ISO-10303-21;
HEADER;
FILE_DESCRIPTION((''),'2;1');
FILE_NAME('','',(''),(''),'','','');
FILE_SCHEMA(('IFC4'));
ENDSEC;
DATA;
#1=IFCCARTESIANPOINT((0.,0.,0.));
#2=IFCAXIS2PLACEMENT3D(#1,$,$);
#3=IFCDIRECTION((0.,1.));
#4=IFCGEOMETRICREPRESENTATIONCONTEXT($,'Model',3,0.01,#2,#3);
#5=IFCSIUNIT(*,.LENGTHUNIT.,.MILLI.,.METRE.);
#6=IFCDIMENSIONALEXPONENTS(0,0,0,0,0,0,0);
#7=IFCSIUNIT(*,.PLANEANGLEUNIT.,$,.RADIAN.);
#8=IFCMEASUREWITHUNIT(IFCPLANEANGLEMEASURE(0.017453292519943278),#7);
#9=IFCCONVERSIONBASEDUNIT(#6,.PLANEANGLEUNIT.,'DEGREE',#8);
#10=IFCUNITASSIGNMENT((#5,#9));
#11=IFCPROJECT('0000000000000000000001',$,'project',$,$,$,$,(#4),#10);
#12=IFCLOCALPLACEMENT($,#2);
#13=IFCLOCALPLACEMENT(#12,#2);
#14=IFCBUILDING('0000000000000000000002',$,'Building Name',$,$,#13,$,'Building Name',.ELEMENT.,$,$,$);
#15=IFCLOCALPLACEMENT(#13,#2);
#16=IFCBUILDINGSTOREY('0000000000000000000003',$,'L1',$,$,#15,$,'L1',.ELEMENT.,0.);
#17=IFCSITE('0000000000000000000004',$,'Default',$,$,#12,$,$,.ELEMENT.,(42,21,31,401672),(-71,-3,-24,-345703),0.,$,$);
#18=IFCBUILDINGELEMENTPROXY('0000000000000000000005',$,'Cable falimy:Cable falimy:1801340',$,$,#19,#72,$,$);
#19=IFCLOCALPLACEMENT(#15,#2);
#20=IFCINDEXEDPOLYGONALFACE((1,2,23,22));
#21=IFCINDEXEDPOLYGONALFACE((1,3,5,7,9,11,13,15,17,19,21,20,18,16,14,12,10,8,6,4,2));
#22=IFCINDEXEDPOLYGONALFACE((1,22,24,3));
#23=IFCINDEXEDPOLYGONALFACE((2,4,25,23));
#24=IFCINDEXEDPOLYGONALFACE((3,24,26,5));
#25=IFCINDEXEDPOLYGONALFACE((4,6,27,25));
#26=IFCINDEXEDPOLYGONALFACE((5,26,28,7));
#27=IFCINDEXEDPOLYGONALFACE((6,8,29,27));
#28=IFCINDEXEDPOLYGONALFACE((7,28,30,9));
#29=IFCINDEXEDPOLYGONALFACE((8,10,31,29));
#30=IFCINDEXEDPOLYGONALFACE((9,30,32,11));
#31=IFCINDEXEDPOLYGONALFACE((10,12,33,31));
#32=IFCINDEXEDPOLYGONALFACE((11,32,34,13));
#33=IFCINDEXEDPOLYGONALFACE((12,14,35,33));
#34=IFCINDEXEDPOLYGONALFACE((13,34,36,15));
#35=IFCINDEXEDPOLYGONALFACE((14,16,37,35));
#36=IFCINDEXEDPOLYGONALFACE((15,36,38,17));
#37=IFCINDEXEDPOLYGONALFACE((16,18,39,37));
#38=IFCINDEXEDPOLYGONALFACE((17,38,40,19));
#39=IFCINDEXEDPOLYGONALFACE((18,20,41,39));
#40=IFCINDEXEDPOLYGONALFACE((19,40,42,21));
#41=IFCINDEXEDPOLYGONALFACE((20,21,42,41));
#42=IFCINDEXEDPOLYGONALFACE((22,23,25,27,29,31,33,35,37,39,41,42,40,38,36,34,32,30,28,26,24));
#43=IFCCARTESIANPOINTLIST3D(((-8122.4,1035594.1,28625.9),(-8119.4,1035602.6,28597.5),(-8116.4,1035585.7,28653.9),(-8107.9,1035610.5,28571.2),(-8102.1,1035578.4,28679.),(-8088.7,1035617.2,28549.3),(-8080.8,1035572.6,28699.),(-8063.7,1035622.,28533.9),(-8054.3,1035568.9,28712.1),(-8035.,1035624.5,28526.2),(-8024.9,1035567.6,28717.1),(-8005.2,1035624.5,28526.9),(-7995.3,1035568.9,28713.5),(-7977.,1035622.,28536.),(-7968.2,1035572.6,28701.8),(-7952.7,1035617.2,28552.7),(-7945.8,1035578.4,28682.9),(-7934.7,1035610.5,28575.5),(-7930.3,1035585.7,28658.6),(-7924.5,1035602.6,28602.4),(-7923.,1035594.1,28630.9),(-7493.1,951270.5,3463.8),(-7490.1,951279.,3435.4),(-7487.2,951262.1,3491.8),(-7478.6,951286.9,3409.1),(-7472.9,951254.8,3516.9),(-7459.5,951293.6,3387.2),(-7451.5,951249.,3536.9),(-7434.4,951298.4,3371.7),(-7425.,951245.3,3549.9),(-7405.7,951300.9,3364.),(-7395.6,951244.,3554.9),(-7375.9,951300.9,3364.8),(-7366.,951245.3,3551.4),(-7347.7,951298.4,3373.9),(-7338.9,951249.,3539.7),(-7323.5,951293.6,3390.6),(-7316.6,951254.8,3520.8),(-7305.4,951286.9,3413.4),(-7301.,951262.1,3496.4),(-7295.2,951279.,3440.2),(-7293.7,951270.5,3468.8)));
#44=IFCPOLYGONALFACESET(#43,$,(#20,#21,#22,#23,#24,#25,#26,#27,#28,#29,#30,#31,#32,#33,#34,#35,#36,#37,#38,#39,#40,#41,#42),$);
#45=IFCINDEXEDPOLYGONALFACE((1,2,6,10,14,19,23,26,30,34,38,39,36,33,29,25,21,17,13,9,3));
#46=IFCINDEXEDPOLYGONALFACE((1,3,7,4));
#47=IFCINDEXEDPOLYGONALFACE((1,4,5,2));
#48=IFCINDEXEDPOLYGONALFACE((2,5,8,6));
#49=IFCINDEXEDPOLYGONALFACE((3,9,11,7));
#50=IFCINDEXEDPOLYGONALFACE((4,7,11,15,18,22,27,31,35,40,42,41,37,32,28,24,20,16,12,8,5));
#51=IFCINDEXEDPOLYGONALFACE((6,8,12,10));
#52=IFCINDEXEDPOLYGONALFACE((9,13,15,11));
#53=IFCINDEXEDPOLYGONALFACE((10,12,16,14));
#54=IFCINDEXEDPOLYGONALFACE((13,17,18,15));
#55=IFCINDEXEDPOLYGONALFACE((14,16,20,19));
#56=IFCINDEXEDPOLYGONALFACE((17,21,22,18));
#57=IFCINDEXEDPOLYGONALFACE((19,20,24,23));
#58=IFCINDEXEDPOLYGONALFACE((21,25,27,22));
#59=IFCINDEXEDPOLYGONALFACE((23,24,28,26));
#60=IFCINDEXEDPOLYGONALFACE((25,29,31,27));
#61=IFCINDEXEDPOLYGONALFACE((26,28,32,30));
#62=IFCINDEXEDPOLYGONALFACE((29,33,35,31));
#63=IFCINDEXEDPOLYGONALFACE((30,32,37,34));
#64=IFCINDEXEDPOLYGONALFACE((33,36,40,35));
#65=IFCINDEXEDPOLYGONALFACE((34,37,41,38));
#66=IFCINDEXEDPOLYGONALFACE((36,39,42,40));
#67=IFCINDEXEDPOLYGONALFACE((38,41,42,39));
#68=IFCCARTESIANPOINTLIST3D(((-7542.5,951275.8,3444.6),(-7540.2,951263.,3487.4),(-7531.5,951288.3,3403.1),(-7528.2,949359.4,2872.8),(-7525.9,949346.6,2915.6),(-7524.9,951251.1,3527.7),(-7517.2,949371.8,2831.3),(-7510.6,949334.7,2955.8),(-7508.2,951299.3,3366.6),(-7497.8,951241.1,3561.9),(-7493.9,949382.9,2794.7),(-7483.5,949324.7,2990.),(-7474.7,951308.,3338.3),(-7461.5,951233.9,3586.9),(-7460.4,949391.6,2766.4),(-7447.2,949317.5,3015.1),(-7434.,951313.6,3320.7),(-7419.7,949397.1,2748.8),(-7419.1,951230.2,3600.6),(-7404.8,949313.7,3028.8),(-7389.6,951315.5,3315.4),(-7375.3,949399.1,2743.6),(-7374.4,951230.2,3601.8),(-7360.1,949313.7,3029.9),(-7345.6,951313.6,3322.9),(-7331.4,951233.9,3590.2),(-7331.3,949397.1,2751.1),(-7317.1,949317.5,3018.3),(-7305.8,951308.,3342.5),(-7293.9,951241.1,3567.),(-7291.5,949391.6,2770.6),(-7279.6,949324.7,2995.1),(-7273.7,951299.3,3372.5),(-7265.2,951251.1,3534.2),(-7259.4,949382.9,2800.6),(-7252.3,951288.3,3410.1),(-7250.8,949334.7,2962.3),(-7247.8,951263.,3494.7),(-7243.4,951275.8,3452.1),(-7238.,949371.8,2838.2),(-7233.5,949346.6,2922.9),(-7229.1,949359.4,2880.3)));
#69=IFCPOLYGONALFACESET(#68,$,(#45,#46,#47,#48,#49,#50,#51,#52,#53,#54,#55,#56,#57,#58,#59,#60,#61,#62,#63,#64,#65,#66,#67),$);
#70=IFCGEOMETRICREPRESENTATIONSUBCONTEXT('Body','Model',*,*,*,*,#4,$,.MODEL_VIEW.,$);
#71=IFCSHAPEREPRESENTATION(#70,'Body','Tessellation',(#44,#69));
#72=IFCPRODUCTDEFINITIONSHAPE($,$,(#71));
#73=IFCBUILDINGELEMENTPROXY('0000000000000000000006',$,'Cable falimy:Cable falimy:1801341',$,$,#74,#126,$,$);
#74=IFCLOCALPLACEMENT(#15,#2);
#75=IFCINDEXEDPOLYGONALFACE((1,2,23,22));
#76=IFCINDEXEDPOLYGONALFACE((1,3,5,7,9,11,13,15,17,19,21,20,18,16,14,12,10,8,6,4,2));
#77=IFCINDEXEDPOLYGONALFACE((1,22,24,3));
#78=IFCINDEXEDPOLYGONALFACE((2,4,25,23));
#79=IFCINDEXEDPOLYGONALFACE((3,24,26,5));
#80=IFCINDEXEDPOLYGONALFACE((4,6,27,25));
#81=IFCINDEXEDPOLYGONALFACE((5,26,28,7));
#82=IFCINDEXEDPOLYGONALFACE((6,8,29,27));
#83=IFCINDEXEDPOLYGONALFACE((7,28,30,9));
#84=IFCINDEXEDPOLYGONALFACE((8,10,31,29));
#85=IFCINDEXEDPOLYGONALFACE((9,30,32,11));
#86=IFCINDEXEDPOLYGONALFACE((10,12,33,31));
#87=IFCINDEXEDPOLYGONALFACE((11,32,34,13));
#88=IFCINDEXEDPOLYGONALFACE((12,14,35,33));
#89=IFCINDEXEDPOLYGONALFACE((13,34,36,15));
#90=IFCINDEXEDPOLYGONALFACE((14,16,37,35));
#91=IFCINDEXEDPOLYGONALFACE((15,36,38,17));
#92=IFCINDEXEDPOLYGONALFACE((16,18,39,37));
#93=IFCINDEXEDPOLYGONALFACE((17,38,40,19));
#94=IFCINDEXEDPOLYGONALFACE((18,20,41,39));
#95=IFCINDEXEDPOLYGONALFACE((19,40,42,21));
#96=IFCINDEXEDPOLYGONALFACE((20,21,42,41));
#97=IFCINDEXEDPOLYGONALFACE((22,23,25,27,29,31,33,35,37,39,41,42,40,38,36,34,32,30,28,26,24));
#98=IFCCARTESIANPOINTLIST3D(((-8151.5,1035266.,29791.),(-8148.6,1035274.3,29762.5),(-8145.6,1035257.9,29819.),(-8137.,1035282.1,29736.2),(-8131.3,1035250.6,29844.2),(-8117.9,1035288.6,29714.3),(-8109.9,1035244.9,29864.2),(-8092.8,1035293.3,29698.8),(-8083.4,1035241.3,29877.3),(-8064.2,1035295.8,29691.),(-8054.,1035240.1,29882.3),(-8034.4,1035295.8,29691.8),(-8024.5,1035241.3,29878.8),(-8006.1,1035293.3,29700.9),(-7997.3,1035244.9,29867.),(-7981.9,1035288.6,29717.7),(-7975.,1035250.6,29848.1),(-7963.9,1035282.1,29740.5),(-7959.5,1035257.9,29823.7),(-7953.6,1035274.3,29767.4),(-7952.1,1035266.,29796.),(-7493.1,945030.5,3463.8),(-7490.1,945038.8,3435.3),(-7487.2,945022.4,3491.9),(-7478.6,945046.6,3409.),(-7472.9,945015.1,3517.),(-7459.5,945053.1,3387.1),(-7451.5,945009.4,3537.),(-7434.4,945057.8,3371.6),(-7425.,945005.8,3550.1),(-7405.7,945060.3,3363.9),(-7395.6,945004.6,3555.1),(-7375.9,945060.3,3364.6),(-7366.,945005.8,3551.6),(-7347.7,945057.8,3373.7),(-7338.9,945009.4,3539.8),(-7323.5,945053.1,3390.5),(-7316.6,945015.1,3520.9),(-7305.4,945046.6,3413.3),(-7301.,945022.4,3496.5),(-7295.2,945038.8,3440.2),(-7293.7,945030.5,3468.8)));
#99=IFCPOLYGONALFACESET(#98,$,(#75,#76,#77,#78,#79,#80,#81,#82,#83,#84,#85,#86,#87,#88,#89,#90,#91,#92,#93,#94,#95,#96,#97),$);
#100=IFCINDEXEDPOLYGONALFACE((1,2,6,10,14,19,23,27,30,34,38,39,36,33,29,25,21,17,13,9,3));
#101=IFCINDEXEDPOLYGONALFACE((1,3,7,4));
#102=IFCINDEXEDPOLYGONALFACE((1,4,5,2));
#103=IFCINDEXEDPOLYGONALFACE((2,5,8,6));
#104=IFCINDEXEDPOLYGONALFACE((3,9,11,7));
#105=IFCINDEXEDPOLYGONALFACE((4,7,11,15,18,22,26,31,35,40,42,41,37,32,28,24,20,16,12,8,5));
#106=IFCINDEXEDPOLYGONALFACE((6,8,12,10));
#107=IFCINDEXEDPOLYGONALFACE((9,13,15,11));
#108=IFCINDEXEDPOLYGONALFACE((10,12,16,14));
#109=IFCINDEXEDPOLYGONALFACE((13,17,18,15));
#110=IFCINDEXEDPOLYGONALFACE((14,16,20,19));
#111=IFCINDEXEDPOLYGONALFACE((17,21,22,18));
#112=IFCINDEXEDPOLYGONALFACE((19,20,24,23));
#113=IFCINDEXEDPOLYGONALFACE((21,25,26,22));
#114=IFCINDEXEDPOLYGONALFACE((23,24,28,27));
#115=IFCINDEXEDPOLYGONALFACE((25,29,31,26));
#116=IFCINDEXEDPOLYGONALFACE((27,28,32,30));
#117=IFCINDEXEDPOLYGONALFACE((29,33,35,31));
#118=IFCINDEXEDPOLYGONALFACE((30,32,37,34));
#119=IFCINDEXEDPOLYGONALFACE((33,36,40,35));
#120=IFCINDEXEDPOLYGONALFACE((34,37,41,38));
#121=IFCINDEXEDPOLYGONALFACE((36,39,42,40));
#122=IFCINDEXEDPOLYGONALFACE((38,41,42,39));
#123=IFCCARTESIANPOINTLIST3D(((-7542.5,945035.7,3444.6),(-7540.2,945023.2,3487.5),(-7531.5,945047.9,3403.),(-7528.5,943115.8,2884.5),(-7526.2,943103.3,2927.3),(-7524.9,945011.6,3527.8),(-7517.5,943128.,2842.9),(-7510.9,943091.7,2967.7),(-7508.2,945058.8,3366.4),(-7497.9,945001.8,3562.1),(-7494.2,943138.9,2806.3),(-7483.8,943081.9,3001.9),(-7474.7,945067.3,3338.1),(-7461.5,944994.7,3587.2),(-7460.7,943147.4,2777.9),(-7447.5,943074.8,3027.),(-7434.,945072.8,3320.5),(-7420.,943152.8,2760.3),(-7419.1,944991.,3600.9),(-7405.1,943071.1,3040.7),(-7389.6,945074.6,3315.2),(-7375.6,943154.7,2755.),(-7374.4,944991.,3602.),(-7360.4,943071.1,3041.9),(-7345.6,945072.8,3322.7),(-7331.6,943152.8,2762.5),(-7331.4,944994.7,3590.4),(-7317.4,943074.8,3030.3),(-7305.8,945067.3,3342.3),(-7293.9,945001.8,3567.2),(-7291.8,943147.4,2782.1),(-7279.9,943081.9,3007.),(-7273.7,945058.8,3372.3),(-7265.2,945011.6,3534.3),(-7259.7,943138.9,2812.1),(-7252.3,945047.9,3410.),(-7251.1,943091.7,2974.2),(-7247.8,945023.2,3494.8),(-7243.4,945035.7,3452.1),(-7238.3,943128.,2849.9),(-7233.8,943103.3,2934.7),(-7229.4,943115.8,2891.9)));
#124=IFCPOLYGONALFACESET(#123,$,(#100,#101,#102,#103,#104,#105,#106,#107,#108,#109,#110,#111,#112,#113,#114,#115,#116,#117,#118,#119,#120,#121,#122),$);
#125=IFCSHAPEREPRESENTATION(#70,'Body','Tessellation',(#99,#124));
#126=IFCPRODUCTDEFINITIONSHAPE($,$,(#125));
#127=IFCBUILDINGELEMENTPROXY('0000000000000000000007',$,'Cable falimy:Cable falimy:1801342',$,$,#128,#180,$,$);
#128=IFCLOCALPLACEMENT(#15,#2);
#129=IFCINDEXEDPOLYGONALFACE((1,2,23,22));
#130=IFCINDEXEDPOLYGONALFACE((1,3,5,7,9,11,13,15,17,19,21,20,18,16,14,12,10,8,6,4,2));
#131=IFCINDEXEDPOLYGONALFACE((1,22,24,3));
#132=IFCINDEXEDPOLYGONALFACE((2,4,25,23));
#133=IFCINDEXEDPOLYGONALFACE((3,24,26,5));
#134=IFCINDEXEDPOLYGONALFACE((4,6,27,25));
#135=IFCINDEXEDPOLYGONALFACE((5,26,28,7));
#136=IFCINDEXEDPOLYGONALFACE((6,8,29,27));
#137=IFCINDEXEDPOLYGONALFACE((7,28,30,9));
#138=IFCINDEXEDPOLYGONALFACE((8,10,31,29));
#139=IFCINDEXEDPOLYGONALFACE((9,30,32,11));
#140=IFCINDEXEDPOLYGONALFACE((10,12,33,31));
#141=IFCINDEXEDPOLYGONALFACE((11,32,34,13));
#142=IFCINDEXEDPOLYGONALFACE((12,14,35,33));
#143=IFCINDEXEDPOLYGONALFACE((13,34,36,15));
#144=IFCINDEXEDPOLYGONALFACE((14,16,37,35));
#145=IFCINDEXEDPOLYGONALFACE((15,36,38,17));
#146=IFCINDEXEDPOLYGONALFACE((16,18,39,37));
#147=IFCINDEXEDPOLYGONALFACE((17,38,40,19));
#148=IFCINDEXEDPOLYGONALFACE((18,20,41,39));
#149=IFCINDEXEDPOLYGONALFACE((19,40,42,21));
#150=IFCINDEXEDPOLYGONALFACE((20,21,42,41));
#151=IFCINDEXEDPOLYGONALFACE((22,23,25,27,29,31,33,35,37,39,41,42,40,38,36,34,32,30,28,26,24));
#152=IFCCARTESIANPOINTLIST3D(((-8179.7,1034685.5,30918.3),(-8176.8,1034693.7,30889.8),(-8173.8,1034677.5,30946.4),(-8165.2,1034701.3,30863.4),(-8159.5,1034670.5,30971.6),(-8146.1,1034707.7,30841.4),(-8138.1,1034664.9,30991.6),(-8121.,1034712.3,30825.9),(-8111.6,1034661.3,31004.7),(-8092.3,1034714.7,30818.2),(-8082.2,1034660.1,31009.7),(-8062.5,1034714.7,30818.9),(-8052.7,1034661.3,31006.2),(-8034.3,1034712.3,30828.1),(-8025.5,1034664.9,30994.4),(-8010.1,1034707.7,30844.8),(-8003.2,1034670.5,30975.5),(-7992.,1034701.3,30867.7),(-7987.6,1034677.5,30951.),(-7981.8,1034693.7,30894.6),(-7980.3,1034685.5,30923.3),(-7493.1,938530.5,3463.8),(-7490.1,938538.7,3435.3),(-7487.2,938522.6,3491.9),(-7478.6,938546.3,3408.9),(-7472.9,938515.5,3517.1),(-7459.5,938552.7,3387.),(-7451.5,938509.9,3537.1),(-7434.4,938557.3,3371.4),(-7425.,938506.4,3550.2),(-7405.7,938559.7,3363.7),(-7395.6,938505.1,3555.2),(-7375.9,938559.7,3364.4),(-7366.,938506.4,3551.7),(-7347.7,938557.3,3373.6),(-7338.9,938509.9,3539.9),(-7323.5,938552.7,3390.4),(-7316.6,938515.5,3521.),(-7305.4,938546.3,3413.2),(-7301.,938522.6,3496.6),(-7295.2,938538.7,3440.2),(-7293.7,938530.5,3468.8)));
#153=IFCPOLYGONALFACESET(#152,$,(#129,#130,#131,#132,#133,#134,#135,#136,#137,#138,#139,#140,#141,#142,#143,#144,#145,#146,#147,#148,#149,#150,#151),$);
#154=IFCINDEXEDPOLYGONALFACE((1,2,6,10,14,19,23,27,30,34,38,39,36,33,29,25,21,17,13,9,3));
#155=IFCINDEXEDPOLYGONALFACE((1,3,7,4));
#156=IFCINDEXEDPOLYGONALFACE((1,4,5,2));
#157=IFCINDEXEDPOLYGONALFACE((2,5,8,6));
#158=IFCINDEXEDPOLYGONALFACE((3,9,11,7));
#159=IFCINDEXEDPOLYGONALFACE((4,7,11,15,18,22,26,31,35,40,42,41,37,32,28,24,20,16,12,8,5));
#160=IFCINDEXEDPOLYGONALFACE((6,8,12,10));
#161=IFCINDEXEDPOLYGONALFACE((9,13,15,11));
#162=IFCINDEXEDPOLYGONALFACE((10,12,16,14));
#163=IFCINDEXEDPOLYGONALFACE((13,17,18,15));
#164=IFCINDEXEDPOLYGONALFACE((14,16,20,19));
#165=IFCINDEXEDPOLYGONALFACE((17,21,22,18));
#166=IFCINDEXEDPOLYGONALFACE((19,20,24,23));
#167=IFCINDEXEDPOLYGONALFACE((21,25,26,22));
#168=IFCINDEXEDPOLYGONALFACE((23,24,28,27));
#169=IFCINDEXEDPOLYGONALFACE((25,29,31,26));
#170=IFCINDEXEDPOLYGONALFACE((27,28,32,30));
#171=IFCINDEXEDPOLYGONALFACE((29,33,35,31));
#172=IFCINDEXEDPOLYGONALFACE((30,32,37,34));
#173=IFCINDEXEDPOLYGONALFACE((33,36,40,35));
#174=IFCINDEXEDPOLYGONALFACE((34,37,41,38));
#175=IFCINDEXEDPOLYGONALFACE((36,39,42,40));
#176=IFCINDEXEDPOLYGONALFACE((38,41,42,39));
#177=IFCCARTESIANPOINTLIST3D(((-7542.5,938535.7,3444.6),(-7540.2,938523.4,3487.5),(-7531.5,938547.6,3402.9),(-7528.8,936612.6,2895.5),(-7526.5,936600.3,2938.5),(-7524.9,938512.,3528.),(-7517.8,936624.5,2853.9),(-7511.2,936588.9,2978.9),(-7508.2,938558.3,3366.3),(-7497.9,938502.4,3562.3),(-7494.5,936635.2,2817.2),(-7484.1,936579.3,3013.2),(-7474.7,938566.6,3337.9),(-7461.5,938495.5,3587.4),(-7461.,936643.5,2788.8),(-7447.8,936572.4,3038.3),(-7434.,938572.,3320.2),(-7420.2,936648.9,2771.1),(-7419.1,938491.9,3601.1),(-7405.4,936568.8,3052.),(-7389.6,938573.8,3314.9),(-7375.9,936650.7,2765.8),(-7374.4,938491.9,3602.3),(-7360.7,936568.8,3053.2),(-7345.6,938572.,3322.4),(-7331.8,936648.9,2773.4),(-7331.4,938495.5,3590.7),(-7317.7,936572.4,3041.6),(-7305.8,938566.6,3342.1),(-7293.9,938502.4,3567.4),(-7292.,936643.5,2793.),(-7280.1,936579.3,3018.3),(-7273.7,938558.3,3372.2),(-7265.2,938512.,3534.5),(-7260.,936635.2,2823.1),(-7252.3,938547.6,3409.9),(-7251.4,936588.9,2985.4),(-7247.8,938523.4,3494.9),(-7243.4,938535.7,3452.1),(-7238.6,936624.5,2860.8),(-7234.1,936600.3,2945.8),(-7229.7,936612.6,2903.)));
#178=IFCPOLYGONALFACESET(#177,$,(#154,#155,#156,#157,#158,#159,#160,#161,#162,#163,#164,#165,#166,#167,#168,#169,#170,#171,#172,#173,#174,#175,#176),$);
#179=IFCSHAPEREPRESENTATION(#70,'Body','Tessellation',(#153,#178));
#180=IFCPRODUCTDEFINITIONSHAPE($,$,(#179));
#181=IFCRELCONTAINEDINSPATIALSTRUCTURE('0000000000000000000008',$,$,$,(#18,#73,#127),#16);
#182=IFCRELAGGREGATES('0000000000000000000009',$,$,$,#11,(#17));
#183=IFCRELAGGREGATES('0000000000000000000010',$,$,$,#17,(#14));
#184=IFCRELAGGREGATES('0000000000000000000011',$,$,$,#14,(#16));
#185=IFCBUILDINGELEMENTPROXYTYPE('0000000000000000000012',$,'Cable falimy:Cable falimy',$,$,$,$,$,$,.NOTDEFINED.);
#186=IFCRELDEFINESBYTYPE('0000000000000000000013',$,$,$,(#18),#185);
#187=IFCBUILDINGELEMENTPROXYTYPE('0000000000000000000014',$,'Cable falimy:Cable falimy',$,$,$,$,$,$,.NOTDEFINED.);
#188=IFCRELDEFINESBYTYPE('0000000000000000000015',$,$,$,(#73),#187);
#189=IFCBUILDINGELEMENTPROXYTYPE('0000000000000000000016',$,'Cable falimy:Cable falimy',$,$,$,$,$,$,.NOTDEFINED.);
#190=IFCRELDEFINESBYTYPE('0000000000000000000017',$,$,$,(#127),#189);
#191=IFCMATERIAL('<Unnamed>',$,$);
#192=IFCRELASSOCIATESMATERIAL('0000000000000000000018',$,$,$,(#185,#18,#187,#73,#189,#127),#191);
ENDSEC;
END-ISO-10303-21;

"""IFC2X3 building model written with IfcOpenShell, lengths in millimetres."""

from ifc_helpers import new_model, entity, si_unit, converted_unit, direction, frame, frame_2d, origin, place, context, subcontext, project, spatial, circle, extrude, source, transform, mapped, material, type_object, type_shapes, element, save


model = new_model("IFC2X3")

# Units and contexts
model_context = context("Model", 3, precision=0.01, world=origin(), true_north=direction((0.0, 1.0)))
body_context = subcontext(model_context, "Body", "Model", "MODEL_VIEW")
ifc_project = project(units=[si_unit("LENGTHUNIT", "METRE", prefix="MILLI"), converted_unit("PLANEANGLEUNIT", "DEGREE", entity("IfcPlaneAngleMeasure", 0.017453292519943278), si_unit("PLANEANGLEUNIT", "RADIAN"), dimensions=[0, 0, 0, 0, 0, 0, 0])], contexts=[model_context])

# Site, building, storey
site_placement = place(None, origin())
site = spatial("IfcSite", under=ifc_project, at=site_placement, Name="Default", CompositionType="ELEMENT", RefLatitude=(42, 21, 31, 401672), RefLongitude=(-71, -3, -24, -345703), RefElevation=0.0)
building_placement = place(site_placement, origin())
building = spatial("IfcBuilding", under=site, at=building_placement, Name="Building Name", LongName="Building Name", CompositionType="ELEMENT")
storey_placement = place(building_placement, origin())
storey = spatial("IfcBuildingStorey", under=building, at=storey_placement, Name="L1", LongName="L1", CompositionType="ELEMENT", Elevation=0.0)

# Shared definitions
ifc_material = material(Name="<Unnamed>")

# Building element proxies
building_element_proxy_type_1 = type_object("IfcBuildingElementProxyType", Name="Cable falimy:Cable falimy", PredefinedType="NOTDEFINED", material=ifc_material)
shared_shape_1 = source(origin(), body_context, "Body", "SweptSolid", [
    extrude(circle(Radius=100.0, at=frame_2d((0.0, 0.0), x_axis=(1.0, 0.0))), frame((0.0, 0.0, 0.0), z_axis=(0.958223, 0.0, 0.286023), x_axis=(-0.286023, 0.0, 0.958223)), (0.0, 0.0, 1.0), 88000.0),
    extrude(circle(Radius=150.0, at=frame_2d((0.0, 0.0), x_axis=(1.0, 0.0))), frame((-1916.4, 0.0, -572.0), z_axis=(0.958223, 0.0, 0.286023), x_axis=(0.286023, 0.0, -0.958223)), (0.0, 0.0, 1.0), 2000.0),
])
type_shapes(building_element_proxy_type_1, [shared_shape_1])
proxy_1_placement = place(storey_placement, frame((-7393.2, 951272.6, 3459.1), z_axis=(-0.025001, 0.0, 0.999687), x_axis=(0.0, 1.0, 0.0)))
element("IfcBuildingElementProxy", 1, at=proxy_1_placement, inside=storey, type_object=building_element_proxy_type_1, material=ifc_material, Name="Cable falimy:Cable falimy:1801340", context=body_context, shape_type="MappedRepresentation", body=[
    mapped(shared_shape_1, transform((0.0, 0.0, 0.0), scale=1.0)),
])
building_element_proxy_type_2 = type_object("IfcBuildingElementProxyType", Name="Cable falimy:Cable falimy", PredefinedType="NOTDEFINED", material=ifc_material)
shared_shape_2 = source(origin(), body_context, "Body", "SweptSolid", [
    extrude(circle(Radius=100.0, at=frame_2d((0.0, 0.0), x_axis=(1.0, 0.0))), frame((0.0, 0.0, 0.0), z_axis=(0.959952, 0.0, 0.280164), x_axis=(-0.280164, 0.0, 0.959952)), (0.0, 0.0, 1.0), 94000.0),
    extrude(circle(Radius=150.0, at=frame_2d((0.0, 0.0), x_axis=(1.0, 0.0))), frame((-1919.9, 0.0, -560.3), z_axis=(0.959952, 0.0, 0.280164), x_axis=(0.280164, 0.0, -0.959952)), (0.0, 0.0, 1.0), 2000.0),
])
type_shapes(building_element_proxy_type_2, [shared_shape_2])
proxy_2_placement = place(storey_placement, frame((-7393.2, 945032.6, 3459.1), z_axis=(-0.025001, 0.0, 0.999687), x_axis=(0.0, 1.0, 0.0)))
element("IfcBuildingElementProxy", 2, at=proxy_2_placement, inside=storey, type_object=building_element_proxy_type_2, material=ifc_material, Name="Cable falimy:Cable falimy:1801341", context=body_context, shape_type="MappedRepresentation", body=[
    mapped(shared_shape_2, transform((0.0, 0.0, 0.0), scale=1.0)),
])
building_element_proxy_type_3 = type_object("IfcBuildingElementProxyType", Name="Cable falimy:Cable falimy", PredefinedType="NOTDEFINED", material=ifc_material)
shared_shape_3 = source(origin(), body_context, "Body", "SweptSolid", [
    extrude(circle(Radius=100.0, at=frame_2d((0.0, 0.0), x_axis=(1.0, 0.0))), frame((0.0, 0.0, 0.0), z_axis=(0.96155, 0.0, 0.274631), x_axis=(-0.274631, 0.0, 0.96155)), (0.0, 0.0, 1.0), 100000.0),
    extrude(circle(Radius=150.0, at=frame_2d((0.0, 0.0), x_axis=(1.0, 0.0))), frame((-1923.1, 0.0, -549.3), z_axis=(0.96155, 0.0, 0.274631), x_axis=(0.274631, 0.0, -0.96155)), (0.0, 0.0, 1.0), 2000.0),
])
type_shapes(building_element_proxy_type_3, [shared_shape_3])
proxy_3_placement = place(storey_placement, frame((-7393.2, 938532.6, 3459.1), z_axis=(-0.025001, 0.0, 0.999687), x_axis=(0.0, 1.0, 0.0)))
element("IfcBuildingElementProxy", 3, at=proxy_3_placement, inside=storey, type_object=building_element_proxy_type_3, material=ifc_material, Name="Cable falimy:Cable falimy:1801342", context=body_context, shape_type="MappedRepresentation", body=[
    mapped(shared_shape_3, transform((0.0, 0.0, 0.0), scale=1.0)),
])

save(model, "model.ifc")
